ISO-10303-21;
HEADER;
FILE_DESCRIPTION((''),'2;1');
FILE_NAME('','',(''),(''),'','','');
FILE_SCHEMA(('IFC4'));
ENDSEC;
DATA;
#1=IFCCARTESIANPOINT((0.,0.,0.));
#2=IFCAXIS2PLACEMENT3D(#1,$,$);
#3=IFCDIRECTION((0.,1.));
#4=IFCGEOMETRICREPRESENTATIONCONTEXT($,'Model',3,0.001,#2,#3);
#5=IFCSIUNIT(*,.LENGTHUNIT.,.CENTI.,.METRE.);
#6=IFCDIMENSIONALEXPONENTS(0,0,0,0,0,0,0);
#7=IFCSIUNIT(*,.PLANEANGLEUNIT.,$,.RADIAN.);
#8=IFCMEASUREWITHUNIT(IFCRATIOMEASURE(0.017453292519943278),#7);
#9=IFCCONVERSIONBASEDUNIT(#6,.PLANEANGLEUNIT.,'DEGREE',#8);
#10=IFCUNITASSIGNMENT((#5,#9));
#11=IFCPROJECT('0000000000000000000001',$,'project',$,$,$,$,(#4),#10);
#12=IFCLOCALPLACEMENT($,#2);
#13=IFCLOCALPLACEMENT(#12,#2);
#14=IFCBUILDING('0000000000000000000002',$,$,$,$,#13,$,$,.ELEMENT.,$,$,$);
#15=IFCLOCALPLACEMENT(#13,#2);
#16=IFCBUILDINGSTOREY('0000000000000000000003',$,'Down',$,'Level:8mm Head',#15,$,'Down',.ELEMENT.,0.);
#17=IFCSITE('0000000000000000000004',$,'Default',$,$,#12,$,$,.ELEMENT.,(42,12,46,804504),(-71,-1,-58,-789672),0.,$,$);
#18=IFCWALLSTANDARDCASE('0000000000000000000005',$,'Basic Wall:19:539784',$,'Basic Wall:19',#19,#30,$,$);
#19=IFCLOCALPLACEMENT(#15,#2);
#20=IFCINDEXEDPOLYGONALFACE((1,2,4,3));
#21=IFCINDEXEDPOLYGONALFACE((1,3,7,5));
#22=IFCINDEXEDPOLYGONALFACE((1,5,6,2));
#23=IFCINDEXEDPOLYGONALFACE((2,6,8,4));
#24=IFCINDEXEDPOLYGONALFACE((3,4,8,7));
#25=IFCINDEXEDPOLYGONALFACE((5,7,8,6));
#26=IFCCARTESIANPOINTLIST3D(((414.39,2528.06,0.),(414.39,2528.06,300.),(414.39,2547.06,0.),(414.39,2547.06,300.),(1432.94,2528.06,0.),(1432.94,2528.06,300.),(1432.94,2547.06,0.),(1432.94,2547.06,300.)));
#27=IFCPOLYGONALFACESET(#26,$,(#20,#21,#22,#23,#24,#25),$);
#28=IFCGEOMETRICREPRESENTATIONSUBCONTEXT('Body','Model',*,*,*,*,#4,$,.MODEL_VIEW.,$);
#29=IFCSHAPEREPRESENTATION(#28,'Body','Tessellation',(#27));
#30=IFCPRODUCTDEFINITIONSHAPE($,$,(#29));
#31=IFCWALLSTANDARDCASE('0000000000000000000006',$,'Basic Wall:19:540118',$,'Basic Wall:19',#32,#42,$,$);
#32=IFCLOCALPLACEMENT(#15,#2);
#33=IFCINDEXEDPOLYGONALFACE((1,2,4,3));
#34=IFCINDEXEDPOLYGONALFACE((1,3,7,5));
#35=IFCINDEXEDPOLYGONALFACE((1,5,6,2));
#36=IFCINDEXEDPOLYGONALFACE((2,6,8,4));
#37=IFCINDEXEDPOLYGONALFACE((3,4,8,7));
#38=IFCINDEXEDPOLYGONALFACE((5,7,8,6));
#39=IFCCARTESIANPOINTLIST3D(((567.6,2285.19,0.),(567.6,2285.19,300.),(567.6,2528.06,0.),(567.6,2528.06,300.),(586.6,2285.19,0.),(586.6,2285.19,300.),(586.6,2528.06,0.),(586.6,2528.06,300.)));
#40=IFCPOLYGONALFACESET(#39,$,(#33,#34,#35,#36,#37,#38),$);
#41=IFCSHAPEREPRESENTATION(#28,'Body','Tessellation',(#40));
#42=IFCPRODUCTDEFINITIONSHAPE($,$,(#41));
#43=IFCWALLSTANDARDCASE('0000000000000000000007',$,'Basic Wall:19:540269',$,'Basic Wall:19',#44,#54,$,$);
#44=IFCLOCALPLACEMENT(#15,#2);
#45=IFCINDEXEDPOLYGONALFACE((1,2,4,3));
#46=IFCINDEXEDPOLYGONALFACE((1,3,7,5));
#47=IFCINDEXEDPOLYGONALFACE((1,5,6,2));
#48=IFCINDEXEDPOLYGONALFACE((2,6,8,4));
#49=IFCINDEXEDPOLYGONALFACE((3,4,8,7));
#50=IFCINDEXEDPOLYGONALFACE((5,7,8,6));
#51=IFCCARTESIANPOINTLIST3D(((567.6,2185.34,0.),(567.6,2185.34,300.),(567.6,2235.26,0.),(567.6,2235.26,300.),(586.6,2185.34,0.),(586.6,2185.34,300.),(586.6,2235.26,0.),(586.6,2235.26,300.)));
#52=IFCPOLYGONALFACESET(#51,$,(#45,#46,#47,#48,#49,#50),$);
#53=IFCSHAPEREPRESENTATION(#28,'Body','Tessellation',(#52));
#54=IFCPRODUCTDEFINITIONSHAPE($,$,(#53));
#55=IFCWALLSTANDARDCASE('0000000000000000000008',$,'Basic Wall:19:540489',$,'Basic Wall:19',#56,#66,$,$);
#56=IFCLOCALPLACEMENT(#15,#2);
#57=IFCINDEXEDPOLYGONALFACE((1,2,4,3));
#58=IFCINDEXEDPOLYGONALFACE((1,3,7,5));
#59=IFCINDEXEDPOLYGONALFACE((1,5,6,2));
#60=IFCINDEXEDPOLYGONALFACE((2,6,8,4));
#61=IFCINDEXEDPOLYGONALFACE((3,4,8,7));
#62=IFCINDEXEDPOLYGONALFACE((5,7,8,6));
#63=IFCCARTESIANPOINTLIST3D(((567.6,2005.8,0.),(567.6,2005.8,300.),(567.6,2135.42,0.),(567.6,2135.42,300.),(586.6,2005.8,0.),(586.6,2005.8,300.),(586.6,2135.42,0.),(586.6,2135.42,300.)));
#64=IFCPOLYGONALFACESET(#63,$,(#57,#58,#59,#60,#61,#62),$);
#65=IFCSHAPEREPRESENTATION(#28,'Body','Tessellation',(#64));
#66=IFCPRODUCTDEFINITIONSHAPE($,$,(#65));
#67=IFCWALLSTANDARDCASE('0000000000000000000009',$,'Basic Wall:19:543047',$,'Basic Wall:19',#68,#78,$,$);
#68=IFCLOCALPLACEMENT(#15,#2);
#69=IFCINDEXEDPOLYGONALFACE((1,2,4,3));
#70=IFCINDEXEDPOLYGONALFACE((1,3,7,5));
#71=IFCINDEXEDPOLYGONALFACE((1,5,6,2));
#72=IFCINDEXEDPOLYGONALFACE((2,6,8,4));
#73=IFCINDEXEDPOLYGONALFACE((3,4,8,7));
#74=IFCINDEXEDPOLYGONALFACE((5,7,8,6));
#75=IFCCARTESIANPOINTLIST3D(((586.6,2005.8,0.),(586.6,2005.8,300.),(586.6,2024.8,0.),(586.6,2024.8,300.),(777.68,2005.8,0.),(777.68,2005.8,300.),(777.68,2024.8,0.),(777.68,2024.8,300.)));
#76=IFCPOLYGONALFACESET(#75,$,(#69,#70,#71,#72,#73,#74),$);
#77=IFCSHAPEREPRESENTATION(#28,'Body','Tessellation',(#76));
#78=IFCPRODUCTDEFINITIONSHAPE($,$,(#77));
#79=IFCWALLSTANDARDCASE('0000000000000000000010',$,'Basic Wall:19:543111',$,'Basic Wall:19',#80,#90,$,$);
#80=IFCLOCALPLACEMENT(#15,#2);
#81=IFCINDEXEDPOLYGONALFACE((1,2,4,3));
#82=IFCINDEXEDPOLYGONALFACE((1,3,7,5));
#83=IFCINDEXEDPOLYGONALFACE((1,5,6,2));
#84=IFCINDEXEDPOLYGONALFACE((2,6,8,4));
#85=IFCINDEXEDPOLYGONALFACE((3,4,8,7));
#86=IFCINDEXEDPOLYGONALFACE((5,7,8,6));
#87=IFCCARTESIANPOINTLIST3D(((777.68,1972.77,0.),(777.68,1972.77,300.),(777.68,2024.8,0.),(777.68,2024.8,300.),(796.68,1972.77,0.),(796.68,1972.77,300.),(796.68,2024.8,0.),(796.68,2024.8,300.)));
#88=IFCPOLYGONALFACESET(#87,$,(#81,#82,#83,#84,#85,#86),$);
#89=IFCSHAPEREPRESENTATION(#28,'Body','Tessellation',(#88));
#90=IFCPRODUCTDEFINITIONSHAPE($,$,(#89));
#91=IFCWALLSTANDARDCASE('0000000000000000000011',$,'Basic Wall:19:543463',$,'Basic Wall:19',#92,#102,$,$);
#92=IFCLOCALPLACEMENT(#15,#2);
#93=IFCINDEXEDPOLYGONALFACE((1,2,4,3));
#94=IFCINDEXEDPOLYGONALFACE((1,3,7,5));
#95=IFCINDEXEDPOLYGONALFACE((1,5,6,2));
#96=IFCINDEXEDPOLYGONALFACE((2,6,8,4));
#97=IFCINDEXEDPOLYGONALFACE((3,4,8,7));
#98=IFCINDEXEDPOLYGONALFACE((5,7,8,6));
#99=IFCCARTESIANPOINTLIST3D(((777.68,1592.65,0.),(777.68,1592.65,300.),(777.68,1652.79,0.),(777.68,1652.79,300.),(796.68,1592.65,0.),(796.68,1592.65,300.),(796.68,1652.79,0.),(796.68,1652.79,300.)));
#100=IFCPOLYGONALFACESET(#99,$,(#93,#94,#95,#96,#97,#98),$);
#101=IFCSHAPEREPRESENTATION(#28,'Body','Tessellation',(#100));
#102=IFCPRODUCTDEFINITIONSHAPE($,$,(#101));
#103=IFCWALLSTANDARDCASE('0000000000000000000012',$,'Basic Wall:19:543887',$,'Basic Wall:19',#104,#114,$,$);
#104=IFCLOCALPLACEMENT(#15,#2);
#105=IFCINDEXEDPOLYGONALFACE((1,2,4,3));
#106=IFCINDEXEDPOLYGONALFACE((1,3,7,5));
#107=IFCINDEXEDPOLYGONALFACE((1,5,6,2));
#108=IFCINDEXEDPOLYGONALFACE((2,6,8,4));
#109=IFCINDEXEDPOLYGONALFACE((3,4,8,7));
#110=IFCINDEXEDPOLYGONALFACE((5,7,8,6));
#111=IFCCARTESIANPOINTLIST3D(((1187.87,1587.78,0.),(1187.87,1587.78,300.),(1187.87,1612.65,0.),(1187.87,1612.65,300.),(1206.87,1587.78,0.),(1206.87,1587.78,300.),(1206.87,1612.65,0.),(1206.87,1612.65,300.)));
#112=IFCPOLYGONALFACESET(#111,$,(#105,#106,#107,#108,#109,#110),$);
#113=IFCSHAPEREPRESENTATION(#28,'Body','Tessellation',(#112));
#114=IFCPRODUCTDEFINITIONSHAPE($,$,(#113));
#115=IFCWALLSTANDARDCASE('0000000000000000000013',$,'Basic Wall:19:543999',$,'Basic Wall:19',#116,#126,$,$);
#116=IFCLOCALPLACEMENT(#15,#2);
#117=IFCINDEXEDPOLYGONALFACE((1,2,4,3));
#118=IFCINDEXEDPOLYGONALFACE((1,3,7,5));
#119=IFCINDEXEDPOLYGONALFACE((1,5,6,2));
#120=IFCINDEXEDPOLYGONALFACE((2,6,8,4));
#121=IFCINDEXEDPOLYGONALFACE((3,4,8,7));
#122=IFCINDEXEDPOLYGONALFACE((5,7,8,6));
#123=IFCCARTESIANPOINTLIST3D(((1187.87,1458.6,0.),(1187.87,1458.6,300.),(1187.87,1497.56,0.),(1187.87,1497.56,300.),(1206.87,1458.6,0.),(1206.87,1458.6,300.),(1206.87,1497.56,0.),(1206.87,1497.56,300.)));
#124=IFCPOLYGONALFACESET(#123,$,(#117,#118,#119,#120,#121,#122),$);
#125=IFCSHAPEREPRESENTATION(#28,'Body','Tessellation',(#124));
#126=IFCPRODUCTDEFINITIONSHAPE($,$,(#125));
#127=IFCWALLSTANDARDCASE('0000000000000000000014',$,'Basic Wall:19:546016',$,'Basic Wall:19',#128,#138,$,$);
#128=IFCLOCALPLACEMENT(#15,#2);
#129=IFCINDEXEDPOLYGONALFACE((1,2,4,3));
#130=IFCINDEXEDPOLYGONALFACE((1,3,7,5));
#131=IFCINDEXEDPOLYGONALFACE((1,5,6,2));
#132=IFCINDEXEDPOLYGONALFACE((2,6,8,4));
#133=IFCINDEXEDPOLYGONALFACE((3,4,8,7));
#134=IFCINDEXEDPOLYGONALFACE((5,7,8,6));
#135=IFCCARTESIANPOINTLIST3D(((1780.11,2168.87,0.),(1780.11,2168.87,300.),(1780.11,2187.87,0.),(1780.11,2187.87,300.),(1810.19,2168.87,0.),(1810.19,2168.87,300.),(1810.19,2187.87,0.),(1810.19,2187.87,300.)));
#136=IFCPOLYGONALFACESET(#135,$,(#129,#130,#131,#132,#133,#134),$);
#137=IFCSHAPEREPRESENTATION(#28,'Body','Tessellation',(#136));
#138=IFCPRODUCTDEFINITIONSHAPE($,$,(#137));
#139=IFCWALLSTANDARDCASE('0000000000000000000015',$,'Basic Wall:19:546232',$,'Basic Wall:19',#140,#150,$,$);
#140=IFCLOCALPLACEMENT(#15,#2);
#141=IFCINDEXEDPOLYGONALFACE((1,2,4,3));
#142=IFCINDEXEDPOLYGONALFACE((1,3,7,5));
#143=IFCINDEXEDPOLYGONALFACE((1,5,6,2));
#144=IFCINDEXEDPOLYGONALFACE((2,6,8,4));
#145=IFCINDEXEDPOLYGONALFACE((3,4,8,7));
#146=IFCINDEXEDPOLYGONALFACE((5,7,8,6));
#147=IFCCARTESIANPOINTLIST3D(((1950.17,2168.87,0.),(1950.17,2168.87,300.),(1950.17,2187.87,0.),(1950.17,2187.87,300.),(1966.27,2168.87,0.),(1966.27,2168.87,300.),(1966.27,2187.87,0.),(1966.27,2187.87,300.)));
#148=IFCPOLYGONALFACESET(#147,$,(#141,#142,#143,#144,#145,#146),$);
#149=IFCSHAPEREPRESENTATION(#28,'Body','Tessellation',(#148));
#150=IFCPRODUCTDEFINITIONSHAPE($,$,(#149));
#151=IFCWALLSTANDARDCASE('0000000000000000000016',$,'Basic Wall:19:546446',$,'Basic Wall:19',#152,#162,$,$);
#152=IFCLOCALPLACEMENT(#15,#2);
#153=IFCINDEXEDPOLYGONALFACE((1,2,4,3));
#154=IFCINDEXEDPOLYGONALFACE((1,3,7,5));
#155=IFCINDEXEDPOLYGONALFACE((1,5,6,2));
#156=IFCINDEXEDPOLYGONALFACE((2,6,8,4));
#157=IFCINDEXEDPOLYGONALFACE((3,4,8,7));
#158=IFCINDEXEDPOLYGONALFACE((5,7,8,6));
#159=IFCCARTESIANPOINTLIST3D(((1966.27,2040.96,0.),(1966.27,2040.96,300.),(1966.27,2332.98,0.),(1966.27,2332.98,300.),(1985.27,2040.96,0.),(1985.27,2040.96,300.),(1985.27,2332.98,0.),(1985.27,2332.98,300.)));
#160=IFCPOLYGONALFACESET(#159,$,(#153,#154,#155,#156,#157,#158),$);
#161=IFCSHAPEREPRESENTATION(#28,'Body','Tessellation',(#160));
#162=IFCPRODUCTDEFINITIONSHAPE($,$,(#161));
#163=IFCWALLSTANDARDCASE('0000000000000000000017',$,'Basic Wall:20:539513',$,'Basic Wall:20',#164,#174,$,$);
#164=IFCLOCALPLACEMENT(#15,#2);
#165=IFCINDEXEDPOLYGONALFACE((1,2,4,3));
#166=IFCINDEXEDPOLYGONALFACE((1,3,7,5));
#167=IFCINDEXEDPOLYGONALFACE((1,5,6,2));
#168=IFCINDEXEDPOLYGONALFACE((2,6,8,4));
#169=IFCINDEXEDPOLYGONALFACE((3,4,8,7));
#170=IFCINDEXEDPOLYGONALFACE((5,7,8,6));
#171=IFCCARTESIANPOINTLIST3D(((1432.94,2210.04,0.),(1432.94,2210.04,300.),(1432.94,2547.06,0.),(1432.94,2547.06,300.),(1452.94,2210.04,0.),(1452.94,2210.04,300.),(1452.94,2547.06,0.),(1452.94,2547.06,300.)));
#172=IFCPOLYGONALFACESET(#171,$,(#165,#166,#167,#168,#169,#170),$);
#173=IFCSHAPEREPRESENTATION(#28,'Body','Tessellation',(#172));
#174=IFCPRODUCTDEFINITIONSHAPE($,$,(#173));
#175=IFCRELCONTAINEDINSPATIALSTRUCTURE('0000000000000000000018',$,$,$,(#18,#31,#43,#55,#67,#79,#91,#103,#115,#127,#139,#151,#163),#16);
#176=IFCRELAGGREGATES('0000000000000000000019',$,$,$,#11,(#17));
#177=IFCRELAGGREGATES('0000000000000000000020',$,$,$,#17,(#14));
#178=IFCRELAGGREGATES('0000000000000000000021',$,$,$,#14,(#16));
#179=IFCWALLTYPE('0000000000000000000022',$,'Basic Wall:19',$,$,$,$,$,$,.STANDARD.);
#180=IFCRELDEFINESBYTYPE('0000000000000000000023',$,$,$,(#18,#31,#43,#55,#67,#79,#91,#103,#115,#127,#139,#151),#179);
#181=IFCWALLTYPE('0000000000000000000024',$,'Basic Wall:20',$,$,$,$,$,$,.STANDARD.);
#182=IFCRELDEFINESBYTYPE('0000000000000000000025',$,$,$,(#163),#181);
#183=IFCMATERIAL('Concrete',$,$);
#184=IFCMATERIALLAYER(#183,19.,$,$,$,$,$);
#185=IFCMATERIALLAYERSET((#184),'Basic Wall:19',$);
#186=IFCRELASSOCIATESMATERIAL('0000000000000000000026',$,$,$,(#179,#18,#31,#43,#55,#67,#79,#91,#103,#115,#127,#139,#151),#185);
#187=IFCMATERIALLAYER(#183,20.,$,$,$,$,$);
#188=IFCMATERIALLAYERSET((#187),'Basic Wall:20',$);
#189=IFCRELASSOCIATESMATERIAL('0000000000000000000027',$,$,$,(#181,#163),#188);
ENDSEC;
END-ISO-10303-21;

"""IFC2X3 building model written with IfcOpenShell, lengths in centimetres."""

from ifc_helpers import new_model, entity, si_unit, converted_unit, direction, frame, frame_2d, origin, place, context, subcontext, project, spatial, rectangle, extrude, material, layer, layer_set, layer_usage, type_object, element, save


model = new_model("IFC2X3")

# Units and contexts
model_context = context("Model", 3, precision=0.001, world=origin(), true_north=direction((0.0, 1.0)))
body_context = subcontext(model_context, "Body", "Model", "MODEL_VIEW")
ifc_project = project(units=[si_unit("LENGTHUNIT", "METRE", prefix="CENTI"), converted_unit("PLANEANGLEUNIT", "DEGREE", entity("IfcRatioMeasure", 0.017453292519943278), si_unit("PLANEANGLEUNIT", "RADIAN"), dimensions=[0, 0, 0, 0, 0, 0, 0])], contexts=[model_context])

# Site, building, storey
site_placement = place(None, origin())
site = spatial("IfcSite", under=ifc_project, at=site_placement, Name="Default", CompositionType="ELEMENT", RefLatitude=(42, 12, 46, 804504), RefLongitude=(-71, -1, -58, -789672), RefElevation=0.0)
building_placement = place(site_placement, origin())
building = spatial("IfcBuilding", under=site, at=building_placement, CompositionType="ELEMENT")
storey_placement = place(building_placement, origin())
storey = spatial("IfcBuildingStorey", under=building, at=storey_placement, Name="Down", ObjectType="Level:8mm Head", LongName="Down", CompositionType="ELEMENT", Elevation=0.0)

# Walls
ifc_material = material(Name="Concrete")
ifc_layer_1 = layer(ifc_material, 19.0)
ifc_layer_set_1 = layer_set([ifc_layer_1], Name="Basic Wall:19")
ifc_layer_usage_1 = layer_usage(ifc_layer_set_1, "AXIS2", "POSITIVE", -9.5)
wall_type_1 = type_object("IfcWallType", Name="Basic Wall:19", PredefinedType="STANDARD", material=ifc_layer_set_1)
wall_1_placement = place(storey_placement, frame((1432.94, 2537.56, 0.0), z_axis=(0.0, 0.0, 1.0), x_axis=(-1.0, 0.0, 0.0)))
element("IfcWallStandardCase", 1, at=wall_1_placement, inside=storey, type_object=wall_type_1, material=ifc_layer_usage_1, Name="Basic Wall:19:539784", ObjectType="Basic Wall:19", context=body_context, shape_type="SweptSolid", body=[
    extrude(rectangle(XDim=1018.55, YDim=19.0, at=frame_2d((509.27, 0.0), x_axis=(-1.0, 0.0))), origin(), (0.0, 0.0, 1.0), 300.0),
])
ifc_layer_usage_2 = layer_usage(ifc_layer_set_1, "AXIS2", "NEGATIVE", 9.5)
wall_2_placement = place(storey_placement, frame((577.1, 2528.06, 0.0), z_axis=(0.0, 0.0, 1.0), x_axis=(0.0, -1.0, 0.0)))
element("IfcWallStandardCase", 2, at=wall_2_placement, inside=storey, type_object=wall_type_1, material=ifc_layer_usage_2, Name="Basic Wall:19:540118", ObjectType="Basic Wall:19", context=body_context, shape_type="SweptSolid", body=[
    extrude(rectangle(XDim=242.88, YDim=19.0, at=frame_2d((121.44, 0.0), x_axis=(-1.0, 0.0))), origin(), (0.0, 0.0, 1.0), 300.0),
])
ifc_layer_usage_3 = layer_usage(ifc_layer_set_1, "AXIS2", "NEGATIVE", 9.5)
wall_3_placement = place(storey_placement, frame((577.1, 2235.26, 0.0), z_axis=(0.0, 0.0, 1.0), x_axis=(0.0, -1.0, 0.0)))
element("IfcWallStandardCase", 3, at=wall_3_placement, inside=storey, type_object=wall_type_1, material=ifc_layer_usage_3, Name="Basic Wall:19:540269", ObjectType="Basic Wall:19", context=body_context, shape_type="SweptSolid", body=[
    extrude(rectangle(XDim=49.92, YDim=19.0, at=frame_2d((24.96, 0.0), x_axis=(-1.0, 0.0))), origin(), (0.0, 0.0, 1.0), 300.0),
])
ifc_layer_usage_4 = layer_usage(ifc_layer_set_1, "AXIS2", "NEGATIVE", 9.5)
wall_4_placement = place(storey_placement, frame((577.1, 2135.42, 0.0), z_axis=(0.0, 0.0, 1.0), x_axis=(0.0, -1.0, 0.0)))
element("IfcWallStandardCase", 4, at=wall_4_placement, inside=storey, type_object=wall_type_1, material=ifc_layer_usage_4, Name="Basic Wall:19:540489", ObjectType="Basic Wall:19", context=body_context, shape_type="SweptSolid", body=[
    extrude(rectangle(XDim=129.61, YDim=19.0, at=frame_2d((64.81, 0.0), x_axis=(-1.0, 0.0))), origin(), (0.0, 0.0, 1.0), 300.0),
])
ifc_layer_usage_5 = layer_usage(ifc_layer_set_1, "AXIS2", "POSITIVE", -9.5)
wall_5_placement = place(storey_placement, frame((586.6, 2015.3, 0.0)))
element("IfcWallStandardCase", 5, at=wall_5_placement, inside=storey, type_object=wall_type_1, material=ifc_layer_usage_5, Name="Basic Wall:19:543047", ObjectType="Basic Wall:19", context=body_context, shape_type="SweptSolid", body=[
    extrude(rectangle(XDim=191.07, YDim=19.0, at=frame_2d((95.54, 0.0), x_axis=(-1.0, 0.0))), origin(), (0.0, 0.0, 1.0), 300.0),
])
ifc_layer_usage_6 = layer_usage(ifc_layer_set_1, "AXIS2", "NEGATIVE", 9.5)
wall_6_placement = place(storey_placement, frame((787.18, 2024.8, 0.0), z_axis=(0.0, 0.0, 1.0), x_axis=(0.0, -1.0, 0.0)))
element("IfcWallStandardCase", 6, at=wall_6_placement, inside=storey, type_object=wall_type_1, material=ifc_layer_usage_6, Name="Basic Wall:19:543111", ObjectType="Basic Wall:19", context=body_context, shape_type="SweptSolid", body=[
    extrude(rectangle(XDim=52.04, YDim=19.0, at=frame_2d((26.02, 0.0), x_axis=(-1.0, 0.0))), origin(), (0.0, 0.0, 1.0), 300.0),
])
ifc_layer_usage_7 = layer_usage(ifc_layer_set_1, "AXIS2", "NEGATIVE", 9.5)
wall_7_placement = place(storey_placement, frame((787.18, 1652.79, 0.0), z_axis=(0.0, 0.0, 1.0), x_axis=(0.0, -1.0, 0.0)))
element("IfcWallStandardCase", 7, at=wall_7_placement, inside=storey, type_object=wall_type_1, material=ifc_layer_usage_7, Name="Basic Wall:19:543463", ObjectType="Basic Wall:19", context=body_context, shape_type="SweptSolid", body=[
    extrude(rectangle(XDim=60.14, YDim=19.0, at=frame_2d((30.07, 0.0), x_axis=(-1.0, 0.0))), origin(), (0.0, 0.0, 1.0), 300.0),
])
ifc_layer_usage_8 = layer_usage(ifc_layer_set_1, "AXIS2", "NEGATIVE", 9.5)
wall_8_placement = place(storey_placement, frame((1197.37, 1612.65, 0.0), z_axis=(0.0, 0.0, 1.0), x_axis=(0.0, -1.0, 0.0)))
element("IfcWallStandardCase", 8, at=wall_8_placement, inside=storey, type_object=wall_type_1, material=ifc_layer_usage_8, Name="Basic Wall:19:543887", ObjectType="Basic Wall:19", context=body_context, shape_type="SweptSolid", body=[
    extrude(rectangle(XDim=24.87, YDim=19.0, at=frame_2d((12.44, 0.0), x_axis=(-1.0, 0.0))), origin(), (0.0, 0.0, 1.0), 300.0),
])
ifc_layer_usage_9 = layer_usage(ifc_layer_set_1, "AXIS2", "NEGATIVE", 9.5)
wall_9_placement = place(storey_placement, frame((1197.37, 1497.56, 0.0), z_axis=(0.0, 0.0, 1.0), x_axis=(0.0, -1.0, 0.0)))
element("IfcWallStandardCase", 9, at=wall_9_placement, inside=storey, type_object=wall_type_1, material=ifc_layer_usage_9, Name="Basic Wall:19:543999", ObjectType="Basic Wall:19", context=body_context, shape_type="SweptSolid", body=[
    extrude(rectangle(XDim=38.97, YDim=19.0, at=frame_2d((19.48, 0.0), x_axis=(-1.0, 0.0))), origin(), (0.0, 0.0, 1.0), 300.0),
])
ifc_layer_usage_10 = layer_usage(ifc_layer_set_1, "AXIS2", "POSITIVE", -9.5)
wall_10_placement = place(storey_placement, frame((1780.11, 2178.37, 0.0)))
element("IfcWallStandardCase", 10, at=wall_10_placement, inside=storey, type_object=wall_type_1, material=ifc_layer_usage_10, Name="Basic Wall:19:546016", ObjectType="Basic Wall:19", context=body_context, shape_type="SweptSolid", body=[
    extrude(rectangle(XDim=30.08, YDim=19.0, at=frame_2d((15.04, 0.0), x_axis=(-1.0, 0.0))), origin(), (0.0, 0.0, 1.0), 300.0),
])
ifc_layer_usage_11 = layer_usage(ifc_layer_set_1, "AXIS2", "POSITIVE", -9.5)
wall_11_placement = place(storey_placement, frame((1950.17, 2178.37, 0.0)))
element("IfcWallStandardCase", 11, at=wall_11_placement, inside=storey, type_object=wall_type_1, material=ifc_layer_usage_11, Name="Basic Wall:19:546232", ObjectType="Basic Wall:19", context=body_context, shape_type="SweptSolid", body=[
    extrude(rectangle(XDim=16.09, YDim=19.0, at=frame_2d((8.05, 0.0), x_axis=(-1.0, 0.0))), origin(), (0.0, 0.0, 1.0), 300.0),
])
ifc_layer_usage_12 = layer_usage(ifc_layer_set_1, "AXIS2", "POSITIVE", -9.5)
wall_12_placement = place(storey_placement, frame((1975.77, 2332.98, 0.0), z_axis=(0.0, 0.0, 1.0), x_axis=(0.0, -1.0, 0.0)))
element("IfcWallStandardCase", 12, at=wall_12_placement, inside=storey, type_object=wall_type_1, material=ifc_layer_usage_12, Name="Basic Wall:19:546446", ObjectType="Basic Wall:19", context=body_context, shape_type="SweptSolid", body=[
    extrude(rectangle(XDim=292.03, YDim=19.0, at=frame_2d((146.01, 0.0), x_axis=(-1.0, 0.0))), origin(), (0.0, 0.0, 1.0), 300.0),
])
ifc_layer_2 = layer(ifc_material, 20.0)
ifc_layer_set_2 = layer_set([ifc_layer_2], Name="Basic Wall:20")
ifc_layer_usage_13 = layer_usage(ifc_layer_set_2, "AXIS2", "NEGATIVE", 10.0)
wall_type_2 = type_object("IfcWallType", Name="Basic Wall:20", PredefinedType="STANDARD", material=ifc_layer_set_2)
wall_13_placement = place(storey_placement, frame((1442.94, 2210.04, 0.0), z_axis=(0.0, 0.0, 1.0), x_axis=(0.0, 1.0, 0.0)))
element("IfcWallStandardCase", 13, at=wall_13_placement, inside=storey, type_object=wall_type_2, material=ifc_layer_usage_13, Name="Basic Wall:20:539513", ObjectType="Basic Wall:20", context=body_context, shape_type="SweptSolid", body=[
    extrude(rectangle(XDim=337.02, YDim=20.0, at=frame_2d((168.51, 0.0), x_axis=(-1.0, 0.0))), origin(), (0.0, 0.0, 1.0), 300.0),
])

save(model, "model.ifc")
